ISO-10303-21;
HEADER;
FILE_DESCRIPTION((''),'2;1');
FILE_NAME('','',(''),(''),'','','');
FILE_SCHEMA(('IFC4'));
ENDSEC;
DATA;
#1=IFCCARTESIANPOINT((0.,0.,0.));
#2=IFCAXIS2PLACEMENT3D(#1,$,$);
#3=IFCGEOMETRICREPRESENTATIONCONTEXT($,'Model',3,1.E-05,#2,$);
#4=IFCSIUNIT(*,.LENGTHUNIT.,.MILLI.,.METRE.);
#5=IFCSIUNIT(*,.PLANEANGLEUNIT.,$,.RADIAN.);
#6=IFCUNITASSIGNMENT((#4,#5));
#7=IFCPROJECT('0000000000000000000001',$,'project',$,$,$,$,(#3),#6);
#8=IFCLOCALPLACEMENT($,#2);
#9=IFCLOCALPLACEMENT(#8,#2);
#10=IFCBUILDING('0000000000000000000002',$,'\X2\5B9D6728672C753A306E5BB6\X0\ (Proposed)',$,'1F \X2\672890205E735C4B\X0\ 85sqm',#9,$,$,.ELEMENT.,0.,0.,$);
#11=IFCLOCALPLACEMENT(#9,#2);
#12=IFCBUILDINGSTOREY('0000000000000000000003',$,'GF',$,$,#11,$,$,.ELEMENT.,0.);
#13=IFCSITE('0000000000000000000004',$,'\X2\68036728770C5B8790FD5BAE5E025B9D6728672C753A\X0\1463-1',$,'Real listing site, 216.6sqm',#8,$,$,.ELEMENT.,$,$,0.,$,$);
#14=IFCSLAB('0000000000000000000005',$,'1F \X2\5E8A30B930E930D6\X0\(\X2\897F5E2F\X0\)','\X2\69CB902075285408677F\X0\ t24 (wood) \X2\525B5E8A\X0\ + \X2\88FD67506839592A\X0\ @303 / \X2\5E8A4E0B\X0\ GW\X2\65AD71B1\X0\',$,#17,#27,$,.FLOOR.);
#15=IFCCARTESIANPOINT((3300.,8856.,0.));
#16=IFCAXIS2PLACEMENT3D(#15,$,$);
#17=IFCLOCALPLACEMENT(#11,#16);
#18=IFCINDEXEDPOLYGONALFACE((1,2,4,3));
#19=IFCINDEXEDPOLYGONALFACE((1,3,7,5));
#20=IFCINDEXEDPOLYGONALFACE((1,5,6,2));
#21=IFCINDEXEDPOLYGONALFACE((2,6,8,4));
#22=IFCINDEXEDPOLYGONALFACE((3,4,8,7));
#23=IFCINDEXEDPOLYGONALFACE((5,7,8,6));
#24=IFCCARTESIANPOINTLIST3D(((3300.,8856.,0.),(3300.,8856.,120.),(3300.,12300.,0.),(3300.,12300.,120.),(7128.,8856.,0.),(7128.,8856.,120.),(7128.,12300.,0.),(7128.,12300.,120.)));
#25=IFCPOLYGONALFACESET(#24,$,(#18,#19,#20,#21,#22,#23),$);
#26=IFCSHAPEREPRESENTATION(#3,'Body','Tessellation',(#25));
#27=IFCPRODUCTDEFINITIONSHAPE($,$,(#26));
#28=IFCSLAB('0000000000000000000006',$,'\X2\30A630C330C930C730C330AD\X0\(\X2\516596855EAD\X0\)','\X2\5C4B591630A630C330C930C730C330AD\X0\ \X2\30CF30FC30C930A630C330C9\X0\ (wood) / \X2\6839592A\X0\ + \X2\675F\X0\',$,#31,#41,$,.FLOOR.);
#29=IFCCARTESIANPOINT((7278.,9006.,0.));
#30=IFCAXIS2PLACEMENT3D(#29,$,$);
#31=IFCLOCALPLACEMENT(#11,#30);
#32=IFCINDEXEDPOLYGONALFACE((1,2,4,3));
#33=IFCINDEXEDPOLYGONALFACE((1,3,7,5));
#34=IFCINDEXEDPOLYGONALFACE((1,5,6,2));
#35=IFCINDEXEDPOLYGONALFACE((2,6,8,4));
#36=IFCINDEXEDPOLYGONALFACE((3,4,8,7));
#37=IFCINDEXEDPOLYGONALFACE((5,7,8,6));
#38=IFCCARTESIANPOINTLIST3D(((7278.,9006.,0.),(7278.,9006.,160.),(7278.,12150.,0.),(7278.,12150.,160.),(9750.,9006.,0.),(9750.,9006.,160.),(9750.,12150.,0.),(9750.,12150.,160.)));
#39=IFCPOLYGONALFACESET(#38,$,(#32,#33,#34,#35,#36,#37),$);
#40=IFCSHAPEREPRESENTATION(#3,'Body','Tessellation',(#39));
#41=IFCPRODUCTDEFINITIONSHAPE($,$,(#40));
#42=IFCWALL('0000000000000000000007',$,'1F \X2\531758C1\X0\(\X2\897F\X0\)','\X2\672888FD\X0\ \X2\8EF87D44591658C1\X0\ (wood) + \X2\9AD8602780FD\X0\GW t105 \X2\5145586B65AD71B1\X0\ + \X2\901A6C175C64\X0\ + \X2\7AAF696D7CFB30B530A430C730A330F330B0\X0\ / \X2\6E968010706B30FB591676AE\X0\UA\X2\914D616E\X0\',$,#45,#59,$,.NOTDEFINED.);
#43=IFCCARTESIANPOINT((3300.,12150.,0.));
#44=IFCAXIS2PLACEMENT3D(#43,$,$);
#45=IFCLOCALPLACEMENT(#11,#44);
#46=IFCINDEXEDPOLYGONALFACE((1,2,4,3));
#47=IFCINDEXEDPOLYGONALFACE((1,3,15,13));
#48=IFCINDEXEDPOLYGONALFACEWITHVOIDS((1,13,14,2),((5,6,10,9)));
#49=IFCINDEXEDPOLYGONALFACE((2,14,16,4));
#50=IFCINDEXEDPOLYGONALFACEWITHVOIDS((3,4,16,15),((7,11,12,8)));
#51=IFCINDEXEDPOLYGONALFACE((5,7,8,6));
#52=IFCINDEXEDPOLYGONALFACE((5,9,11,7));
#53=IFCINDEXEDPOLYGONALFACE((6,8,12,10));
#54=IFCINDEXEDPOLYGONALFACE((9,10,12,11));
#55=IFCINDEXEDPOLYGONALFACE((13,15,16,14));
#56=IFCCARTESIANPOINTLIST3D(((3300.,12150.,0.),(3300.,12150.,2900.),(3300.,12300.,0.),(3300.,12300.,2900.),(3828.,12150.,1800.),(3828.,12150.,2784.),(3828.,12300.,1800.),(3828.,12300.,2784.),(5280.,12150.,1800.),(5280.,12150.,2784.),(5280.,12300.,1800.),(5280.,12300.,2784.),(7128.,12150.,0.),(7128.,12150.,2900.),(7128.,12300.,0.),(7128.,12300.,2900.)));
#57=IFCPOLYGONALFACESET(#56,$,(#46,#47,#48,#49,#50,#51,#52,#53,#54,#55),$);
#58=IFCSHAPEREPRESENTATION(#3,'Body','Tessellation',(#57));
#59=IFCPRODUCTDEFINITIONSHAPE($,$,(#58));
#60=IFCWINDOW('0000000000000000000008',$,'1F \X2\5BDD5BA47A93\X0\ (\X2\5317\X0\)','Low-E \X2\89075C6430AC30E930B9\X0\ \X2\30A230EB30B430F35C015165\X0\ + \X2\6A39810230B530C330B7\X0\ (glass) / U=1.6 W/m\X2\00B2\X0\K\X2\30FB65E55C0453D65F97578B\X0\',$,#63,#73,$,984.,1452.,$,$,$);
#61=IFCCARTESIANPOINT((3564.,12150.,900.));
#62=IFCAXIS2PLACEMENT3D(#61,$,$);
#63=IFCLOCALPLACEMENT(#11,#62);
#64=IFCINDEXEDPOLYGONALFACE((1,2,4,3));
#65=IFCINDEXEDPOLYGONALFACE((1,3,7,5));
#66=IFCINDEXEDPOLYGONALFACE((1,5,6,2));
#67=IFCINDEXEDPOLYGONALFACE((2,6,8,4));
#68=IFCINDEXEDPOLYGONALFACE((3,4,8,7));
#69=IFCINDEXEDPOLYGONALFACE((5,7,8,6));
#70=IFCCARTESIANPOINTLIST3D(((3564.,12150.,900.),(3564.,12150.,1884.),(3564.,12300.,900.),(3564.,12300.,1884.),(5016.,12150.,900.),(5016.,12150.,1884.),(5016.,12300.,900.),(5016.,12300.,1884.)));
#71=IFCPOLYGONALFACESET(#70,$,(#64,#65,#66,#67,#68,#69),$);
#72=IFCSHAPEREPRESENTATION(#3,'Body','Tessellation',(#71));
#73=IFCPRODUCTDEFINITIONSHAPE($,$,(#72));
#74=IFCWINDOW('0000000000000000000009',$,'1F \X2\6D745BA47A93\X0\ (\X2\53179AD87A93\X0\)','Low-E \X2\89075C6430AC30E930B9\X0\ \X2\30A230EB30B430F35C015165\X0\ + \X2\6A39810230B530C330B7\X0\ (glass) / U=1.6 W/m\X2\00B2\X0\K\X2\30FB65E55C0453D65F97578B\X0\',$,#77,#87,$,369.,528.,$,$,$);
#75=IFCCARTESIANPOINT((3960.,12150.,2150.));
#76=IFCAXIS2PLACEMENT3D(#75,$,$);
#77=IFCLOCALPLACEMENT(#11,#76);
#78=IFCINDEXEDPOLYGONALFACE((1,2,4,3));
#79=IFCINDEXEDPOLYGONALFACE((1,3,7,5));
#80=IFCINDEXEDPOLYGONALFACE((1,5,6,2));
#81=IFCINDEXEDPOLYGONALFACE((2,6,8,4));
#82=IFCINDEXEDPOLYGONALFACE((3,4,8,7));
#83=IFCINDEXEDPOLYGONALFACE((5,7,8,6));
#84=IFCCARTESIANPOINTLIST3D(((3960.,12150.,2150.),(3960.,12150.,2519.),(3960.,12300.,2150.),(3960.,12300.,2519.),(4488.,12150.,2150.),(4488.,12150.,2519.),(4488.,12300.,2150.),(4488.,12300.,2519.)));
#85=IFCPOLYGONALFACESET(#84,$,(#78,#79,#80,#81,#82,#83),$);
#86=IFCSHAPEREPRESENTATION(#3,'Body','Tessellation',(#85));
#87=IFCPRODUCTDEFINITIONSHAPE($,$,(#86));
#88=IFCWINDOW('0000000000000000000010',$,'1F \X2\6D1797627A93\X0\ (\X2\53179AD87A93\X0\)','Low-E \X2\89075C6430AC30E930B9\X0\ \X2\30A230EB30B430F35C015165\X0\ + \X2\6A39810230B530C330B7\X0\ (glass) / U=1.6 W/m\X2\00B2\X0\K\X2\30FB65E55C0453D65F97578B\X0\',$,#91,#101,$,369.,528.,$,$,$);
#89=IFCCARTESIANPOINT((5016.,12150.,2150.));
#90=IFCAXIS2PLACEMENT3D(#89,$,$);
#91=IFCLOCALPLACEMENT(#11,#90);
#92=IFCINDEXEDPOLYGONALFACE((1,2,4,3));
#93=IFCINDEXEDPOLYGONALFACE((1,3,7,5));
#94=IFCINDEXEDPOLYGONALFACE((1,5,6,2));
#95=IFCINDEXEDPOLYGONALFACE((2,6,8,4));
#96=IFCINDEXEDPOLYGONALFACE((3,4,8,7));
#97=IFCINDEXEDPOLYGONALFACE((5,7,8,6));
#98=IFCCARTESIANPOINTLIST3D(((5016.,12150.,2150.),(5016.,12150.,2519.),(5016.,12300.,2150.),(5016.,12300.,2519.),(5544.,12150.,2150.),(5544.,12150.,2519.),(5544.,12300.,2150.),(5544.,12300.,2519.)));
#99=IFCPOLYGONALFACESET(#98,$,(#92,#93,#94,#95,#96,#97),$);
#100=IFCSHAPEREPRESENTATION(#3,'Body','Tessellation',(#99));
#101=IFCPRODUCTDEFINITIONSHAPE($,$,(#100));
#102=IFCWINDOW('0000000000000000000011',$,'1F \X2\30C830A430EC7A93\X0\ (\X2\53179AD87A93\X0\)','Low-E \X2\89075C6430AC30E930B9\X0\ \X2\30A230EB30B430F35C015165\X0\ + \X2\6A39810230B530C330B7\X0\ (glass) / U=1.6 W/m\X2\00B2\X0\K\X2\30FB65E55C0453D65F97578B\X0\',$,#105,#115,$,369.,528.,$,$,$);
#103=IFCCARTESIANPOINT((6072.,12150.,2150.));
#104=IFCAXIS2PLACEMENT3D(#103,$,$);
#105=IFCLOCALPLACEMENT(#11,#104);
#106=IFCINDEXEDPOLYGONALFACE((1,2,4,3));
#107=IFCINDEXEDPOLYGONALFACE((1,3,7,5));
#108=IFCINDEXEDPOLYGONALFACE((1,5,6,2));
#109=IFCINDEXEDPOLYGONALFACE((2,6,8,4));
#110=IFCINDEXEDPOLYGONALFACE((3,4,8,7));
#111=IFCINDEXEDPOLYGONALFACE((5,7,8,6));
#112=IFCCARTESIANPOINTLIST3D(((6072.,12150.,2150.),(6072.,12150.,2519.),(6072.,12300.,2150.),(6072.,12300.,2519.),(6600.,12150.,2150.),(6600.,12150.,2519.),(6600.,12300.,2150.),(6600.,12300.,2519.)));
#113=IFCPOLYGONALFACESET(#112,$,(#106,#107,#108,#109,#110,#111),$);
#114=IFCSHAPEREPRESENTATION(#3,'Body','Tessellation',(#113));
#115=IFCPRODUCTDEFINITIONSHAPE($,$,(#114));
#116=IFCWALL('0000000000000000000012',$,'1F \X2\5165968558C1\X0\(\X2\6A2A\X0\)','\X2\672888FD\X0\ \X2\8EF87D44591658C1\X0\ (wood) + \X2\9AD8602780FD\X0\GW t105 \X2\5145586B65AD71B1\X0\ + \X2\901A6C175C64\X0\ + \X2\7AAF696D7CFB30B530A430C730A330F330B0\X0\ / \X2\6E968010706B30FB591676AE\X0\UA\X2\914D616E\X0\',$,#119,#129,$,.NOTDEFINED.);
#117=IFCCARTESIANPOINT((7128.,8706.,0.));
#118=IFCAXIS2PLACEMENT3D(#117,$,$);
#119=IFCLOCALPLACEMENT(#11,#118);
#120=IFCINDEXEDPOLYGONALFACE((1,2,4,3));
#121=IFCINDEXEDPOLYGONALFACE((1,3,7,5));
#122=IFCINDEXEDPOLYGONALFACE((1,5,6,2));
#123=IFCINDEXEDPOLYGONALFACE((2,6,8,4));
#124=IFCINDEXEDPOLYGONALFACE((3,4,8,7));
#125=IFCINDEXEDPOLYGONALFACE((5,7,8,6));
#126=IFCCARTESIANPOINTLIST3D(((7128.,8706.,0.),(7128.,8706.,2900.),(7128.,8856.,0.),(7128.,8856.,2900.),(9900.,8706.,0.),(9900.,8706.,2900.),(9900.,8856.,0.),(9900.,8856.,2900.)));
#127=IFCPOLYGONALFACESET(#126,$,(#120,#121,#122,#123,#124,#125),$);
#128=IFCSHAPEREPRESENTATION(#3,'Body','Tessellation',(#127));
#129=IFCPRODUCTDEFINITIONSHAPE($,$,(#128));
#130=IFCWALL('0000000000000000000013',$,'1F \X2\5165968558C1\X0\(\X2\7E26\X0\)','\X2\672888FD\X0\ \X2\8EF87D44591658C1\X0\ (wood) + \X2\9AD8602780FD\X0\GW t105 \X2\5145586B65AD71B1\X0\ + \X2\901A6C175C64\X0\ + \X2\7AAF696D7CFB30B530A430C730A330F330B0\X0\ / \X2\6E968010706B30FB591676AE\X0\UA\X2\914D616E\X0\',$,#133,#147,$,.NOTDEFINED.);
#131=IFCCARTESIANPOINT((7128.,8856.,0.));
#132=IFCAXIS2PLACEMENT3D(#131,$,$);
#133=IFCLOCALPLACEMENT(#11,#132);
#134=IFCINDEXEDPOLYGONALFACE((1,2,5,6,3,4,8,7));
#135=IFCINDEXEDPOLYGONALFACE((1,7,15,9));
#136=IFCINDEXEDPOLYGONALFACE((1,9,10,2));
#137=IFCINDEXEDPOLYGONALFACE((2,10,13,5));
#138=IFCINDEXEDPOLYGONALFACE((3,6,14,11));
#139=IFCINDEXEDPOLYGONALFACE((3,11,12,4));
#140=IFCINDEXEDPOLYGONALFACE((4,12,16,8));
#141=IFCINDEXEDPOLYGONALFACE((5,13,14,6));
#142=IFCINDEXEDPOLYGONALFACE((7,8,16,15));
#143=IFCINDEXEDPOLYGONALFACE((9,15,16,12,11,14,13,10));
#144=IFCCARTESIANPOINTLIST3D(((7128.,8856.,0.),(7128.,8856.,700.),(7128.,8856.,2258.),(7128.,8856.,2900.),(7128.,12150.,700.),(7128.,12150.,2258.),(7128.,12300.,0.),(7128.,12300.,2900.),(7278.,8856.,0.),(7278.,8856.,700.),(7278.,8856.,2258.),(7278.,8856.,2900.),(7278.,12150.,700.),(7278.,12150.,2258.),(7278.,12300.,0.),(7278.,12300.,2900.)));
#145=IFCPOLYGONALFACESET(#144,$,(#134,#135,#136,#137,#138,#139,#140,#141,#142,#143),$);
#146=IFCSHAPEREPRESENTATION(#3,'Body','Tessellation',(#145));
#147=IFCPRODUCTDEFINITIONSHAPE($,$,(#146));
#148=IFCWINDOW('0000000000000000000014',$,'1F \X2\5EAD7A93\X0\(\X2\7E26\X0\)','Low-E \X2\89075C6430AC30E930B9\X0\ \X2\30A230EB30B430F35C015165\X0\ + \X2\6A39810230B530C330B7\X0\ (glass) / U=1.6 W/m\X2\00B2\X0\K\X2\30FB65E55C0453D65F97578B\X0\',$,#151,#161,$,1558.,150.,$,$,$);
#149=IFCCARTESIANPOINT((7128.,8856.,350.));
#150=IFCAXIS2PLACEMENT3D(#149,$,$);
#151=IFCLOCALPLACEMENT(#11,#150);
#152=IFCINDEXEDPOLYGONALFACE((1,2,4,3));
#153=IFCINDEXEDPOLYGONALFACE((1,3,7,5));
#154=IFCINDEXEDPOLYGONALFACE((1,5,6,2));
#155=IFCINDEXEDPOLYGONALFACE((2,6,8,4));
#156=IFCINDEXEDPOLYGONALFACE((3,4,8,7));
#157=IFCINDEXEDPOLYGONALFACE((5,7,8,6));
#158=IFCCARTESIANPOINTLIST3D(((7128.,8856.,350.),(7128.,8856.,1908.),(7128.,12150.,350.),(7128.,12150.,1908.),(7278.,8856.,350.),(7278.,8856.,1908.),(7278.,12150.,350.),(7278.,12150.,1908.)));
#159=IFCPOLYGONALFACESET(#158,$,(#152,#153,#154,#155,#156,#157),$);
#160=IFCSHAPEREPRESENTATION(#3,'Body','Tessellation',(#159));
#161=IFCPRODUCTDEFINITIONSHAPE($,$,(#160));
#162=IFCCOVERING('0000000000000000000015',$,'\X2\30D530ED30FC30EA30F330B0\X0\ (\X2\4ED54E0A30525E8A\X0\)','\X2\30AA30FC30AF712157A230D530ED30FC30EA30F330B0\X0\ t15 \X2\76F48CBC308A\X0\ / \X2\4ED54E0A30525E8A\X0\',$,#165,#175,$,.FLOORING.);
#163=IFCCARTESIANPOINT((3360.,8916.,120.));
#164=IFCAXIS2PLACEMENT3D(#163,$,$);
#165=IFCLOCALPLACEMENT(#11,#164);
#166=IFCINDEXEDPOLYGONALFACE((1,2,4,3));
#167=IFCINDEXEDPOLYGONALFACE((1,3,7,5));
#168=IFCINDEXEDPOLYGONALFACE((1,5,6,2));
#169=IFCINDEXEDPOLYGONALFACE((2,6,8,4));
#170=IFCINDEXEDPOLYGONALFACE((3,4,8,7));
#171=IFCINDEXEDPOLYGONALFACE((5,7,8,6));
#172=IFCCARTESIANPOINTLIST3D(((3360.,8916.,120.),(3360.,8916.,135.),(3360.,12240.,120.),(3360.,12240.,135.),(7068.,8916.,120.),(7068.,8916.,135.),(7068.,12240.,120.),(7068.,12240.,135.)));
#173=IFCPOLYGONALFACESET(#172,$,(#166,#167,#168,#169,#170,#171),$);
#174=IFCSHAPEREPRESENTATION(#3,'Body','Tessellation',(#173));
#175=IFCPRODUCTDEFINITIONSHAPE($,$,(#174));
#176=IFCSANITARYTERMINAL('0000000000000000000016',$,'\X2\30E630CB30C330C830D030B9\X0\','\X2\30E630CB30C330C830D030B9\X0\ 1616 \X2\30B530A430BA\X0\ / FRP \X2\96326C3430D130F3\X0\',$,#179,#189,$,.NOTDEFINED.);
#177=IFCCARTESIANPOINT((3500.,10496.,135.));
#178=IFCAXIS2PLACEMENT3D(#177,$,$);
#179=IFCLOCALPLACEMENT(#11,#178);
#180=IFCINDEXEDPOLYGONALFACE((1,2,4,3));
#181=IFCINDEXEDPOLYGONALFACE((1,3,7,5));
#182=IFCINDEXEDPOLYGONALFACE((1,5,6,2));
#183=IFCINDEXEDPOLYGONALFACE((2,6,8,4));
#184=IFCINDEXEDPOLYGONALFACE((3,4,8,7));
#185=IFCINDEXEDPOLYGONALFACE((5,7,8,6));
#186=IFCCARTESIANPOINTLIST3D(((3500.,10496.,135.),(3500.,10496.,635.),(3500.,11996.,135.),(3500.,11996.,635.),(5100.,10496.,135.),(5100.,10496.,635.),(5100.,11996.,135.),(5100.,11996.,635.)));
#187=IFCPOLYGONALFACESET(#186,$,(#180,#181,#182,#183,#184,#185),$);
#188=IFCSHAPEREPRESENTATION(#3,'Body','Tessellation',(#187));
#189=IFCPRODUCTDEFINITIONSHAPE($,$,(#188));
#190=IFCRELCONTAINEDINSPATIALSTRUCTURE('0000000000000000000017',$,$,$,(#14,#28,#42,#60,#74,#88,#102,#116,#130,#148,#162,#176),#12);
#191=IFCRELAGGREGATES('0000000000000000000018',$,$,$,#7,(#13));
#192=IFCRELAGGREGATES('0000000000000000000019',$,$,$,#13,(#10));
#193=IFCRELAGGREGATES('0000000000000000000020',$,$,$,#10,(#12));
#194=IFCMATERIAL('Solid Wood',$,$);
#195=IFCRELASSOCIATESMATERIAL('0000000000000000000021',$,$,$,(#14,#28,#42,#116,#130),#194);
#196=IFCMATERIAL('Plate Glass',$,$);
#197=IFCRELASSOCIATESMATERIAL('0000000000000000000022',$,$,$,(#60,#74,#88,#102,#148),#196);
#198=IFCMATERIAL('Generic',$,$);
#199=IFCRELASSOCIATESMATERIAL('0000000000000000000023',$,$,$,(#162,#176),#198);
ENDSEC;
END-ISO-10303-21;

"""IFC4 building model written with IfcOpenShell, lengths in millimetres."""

from ifc_helpers import new_model, si_unit, frame, frame_2d, origin, place, context, project, spatial, rectangle, extrude, material, element, fill, save


model = new_model("IFC4")

# Units and contexts
model_context = context("Model", 3, precision=1e-05, world=origin())
ifc_project = project(units=[si_unit("LENGTHUNIT", "METRE", prefix="MILLI"), si_unit("PLANEANGLEUNIT", "RADIAN")], contexts=[model_context])

# Site, building, storey
site_placement = place(None, origin())
site = spatial("IfcSite", under=ifc_project, at=site_placement, Name="栃木県宇都宮市宝木本町1463-1", ObjectType="Real listing site, 216.6sqm", CompositionType="ELEMENT", RefElevation=0.0)
building_placement = place(site_placement, origin())
building = spatial("IfcBuilding", under=site, at=building_placement, Name="宝木本町の家 (Proposed)", ObjectType="1F 木造平屋 85sqm", CompositionType="ELEMENT", ElevationOfRefHeight=0.0, ElevationOfTerrain=0.0)
storey_placement = place(building_placement, origin())
storey = spatial("IfcBuildingStorey", under=building, at=storey_placement, Name="GF", CompositionType="ELEMENT", Elevation=0.0)

# Slabs
ifc_material_1 = material(Name="Solid Wood")
slab_1_placement = place(storey_placement, frame((3300.0, 8856.0, 0.0)))
element("IfcSlab", 1, at=slab_1_placement, inside=storey, material=ifc_material_1, Name="1F 床スラブ(西帯)", Description="構造用合板 t24 (wood) 剛床 + 製材根太 @303 / 床下 GW断熱", PredefinedType="FLOOR", context=model_context, shape_type="SweptSolid", body=[
    extrude(rectangle(XDim=3828.0, YDim=3444.0, at=frame_2d((1914.0, 1722.0))), frame((3300.0, 8856.0, 0.0)), (0.0, 0.0, 1.0), 120.0),
])
slab_2_placement = place(storey_placement, frame((7278.0, 9006.0, 0.0)))
element("IfcSlab", 2, at=slab_2_placement, inside=storey, material=ifc_material_1, Name="ウッドデッキ(入隅庭)", Description="屋外ウッドデッキ ハードウッド (wood) / 根太 + 束", PredefinedType="FLOOR", context=model_context, shape_type="SweptSolid", body=[
    extrude(rectangle(XDim=2472.0, YDim=3144.0, at=frame_2d((1236.0, 1572.0))), frame((7278.0, 9006.0, 0.0)), (0.0, 0.0, 1.0), 160.0),
])

# Wall, openings, windows
wall_1_placement = place(storey_placement, frame((3300.0, 12150.0, 0.0)))
wall_1 = element("IfcWall", 3, at=wall_1_placement, inside=storey, material=ifc_material_1, Name="1F 北壁(西)", Description="木製 軸組外壁 (wood) + 高性能GW t105 充填断熱 + 通気層 + 窯業系サイディング / 準耐火・外皮UA配慮", PredefinedType="NOTDEFINED", context=model_context, shape_type="SweptSolid", body=[
    extrude(rectangle(XDim=3828.0, YDim=150.0, at=frame_2d((1914.0, 75.0))), frame((3300.0, 12150.0, 0.0)), (0.0, 0.0, 1.0), 2900.0),
])
opening_1_placement = place(storey_placement, frame((3564.0, 12150.0, 900.0)))
opening_1 = element("IfcOpeningElement", 4, at=opening_1_placement, cuts=wall_1, PredefinedType="NOTDEFINED", context=model_context, shape_type="SweptSolid", body=[
    extrude(rectangle(XDim=1452.0, YDim=150.0, at=frame_2d((726.0, 75.0))), frame((3564.0, 12150.0, 900.0)), (0.0, 0.0, 1.0), 984.0),
])
opening_2_placement = place(storey_placement, frame((3960.0, 12150.0, 2150.0)))
opening_2 = element("IfcOpeningElement", 5, at=opening_2_placement, cuts=wall_1, PredefinedType="NOTDEFINED", context=model_context, shape_type="SweptSolid", body=[
    extrude(rectangle(XDim=528.0, YDim=150.0, at=frame_2d((264.0, 75.0))), frame((3960.0, 12150.0, 2150.0)), (0.0, 0.0, 1.0), 369.0),
])
opening_3_placement = place(storey_placement, frame((5016.0, 12150.0, 2150.0)))
opening_3 = element("IfcOpeningElement", 6, at=opening_3_placement, cuts=wall_1, PredefinedType="NOTDEFINED", context=model_context, shape_type="SweptSolid", body=[
    extrude(rectangle(XDim=528.0, YDim=150.0, at=frame_2d((264.0, 75.0))), frame((5016.0, 12150.0, 2150.0)), (0.0, 0.0, 1.0), 369.0),
])
opening_4_placement = place(storey_placement, frame((6072.0, 12150.0, 2150.0)))
opening_4 = element("IfcOpeningElement", 7, at=opening_4_placement, cuts=wall_1, PredefinedType="NOTDEFINED", context=model_context, shape_type="SweptSolid", body=[
    extrude(rectangle(XDim=528.0, YDim=150.0, at=frame_2d((264.0, 75.0))), frame((6072.0, 12150.0, 2150.0)), (0.0, 0.0, 1.0), 369.0),
])
ifc_material_2 = material(Name="Plate Glass")
window_1_placement = place(storey_placement, frame((3564.0, 12150.0, 900.0)))
window_1 = element("IfcWindow", 8, at=window_1_placement, inside=storey, material=ifc_material_2, Name="1F 寝室窓 (北)", Description="Low-E 複層ガラス アルゴン封入 + 樹脂サッシ (glass) / U=1.6 W/m²K・日射取得型", OverallHeight=984.0, OverallWidth=1452.0, context=model_context, shape_type="SweptSolid", body=[
    extrude(rectangle(XDim=1452.0, YDim=150.0, at=frame_2d((726.0, 75.0))), frame((3564.0, 12150.0, 900.0)), (0.0, 0.0, 1.0), 984.0),
])
fill(opening_1, window_1)
window_2_placement = place(storey_placement, frame((3960.0, 12150.0, 2150.0)))
window_2 = element("IfcWindow", 9, at=window_2_placement, inside=storey, material=ifc_material_2, Name="1F 浴室窓 (北高窓)", Description="Low-E 複層ガラス アルゴン封入 + 樹脂サッシ (glass) / U=1.6 W/m²K・日射取得型", OverallHeight=369.0, OverallWidth=528.0, context=model_context, shape_type="SweptSolid", body=[
    extrude(rectangle(XDim=528.0, YDim=150.0, at=frame_2d((264.0, 75.0))), frame((3960.0, 12150.0, 2150.0)), (0.0, 0.0, 1.0), 369.0),
])
fill(opening_2, window_2)
window_3_placement = place(storey_placement, frame((5016.0, 12150.0, 2150.0)))
window_3 = element("IfcWindow", 10, at=window_3_placement, inside=storey, material=ifc_material_2, Name="1F 洗面窓 (北高窓)", Description="Low-E 複層ガラス アルゴン封入 + 樹脂サッシ (glass) / U=1.6 W/m²K・日射取得型", OverallHeight=369.0, OverallWidth=528.0, context=model_context, shape_type="SweptSolid", body=[
    extrude(rectangle(XDim=528.0, YDim=150.0, at=frame_2d((264.0, 75.0))), frame((5016.0, 12150.0, 2150.0)), (0.0, 0.0, 1.0), 369.0),
])
fill(opening_3, window_3)
window_4_placement = place(storey_placement, frame((6072.0, 12150.0, 2150.0)))
window_4 = element("IfcWindow", 11, at=window_4_placement, inside=storey, material=ifc_material_2, Name="1F トイレ窓 (北高窓)", Description="Low-E 複層ガラス アルゴン封入 + 樹脂サッシ (glass) / U=1.6 W/m²K・日射取得型", OverallHeight=369.0, OverallWidth=528.0, context=model_context, shape_type="SweptSolid", body=[
    extrude(rectangle(XDim=528.0, YDim=150.0, at=frame_2d((264.0, 75.0))), frame((6072.0, 12150.0, 2150.0)), (0.0, 0.0, 1.0), 369.0),
])
fill(opening_4, window_4)

# Wall
wall_2_placement = place(storey_placement, frame((7128.0, 8706.0, 0.0)))
element("IfcWall", 12, at=wall_2_placement, inside=storey, material=ifc_material_1, Name="1F 入隅壁(横)", Description="木製 軸組外壁 (wood) + 高性能GW t105 充填断熱 + 通気層 + 窯業系サイディング / 準耐火・外皮UA配慮", PredefinedType="NOTDEFINED", context=model_context, shape_type="SweptSolid", body=[
    extrude(rectangle(XDim=2772.0, YDim=150.0, at=frame_2d((1386.0, 75.0))), frame((7128.0, 8706.0, 0.0)), (0.0, 0.0, 1.0), 2900.0),
])

# Wall, opening, window
wall_3_placement = place(storey_placement, frame((7128.0, 8856.0, 0.0)))
wall_3 = element("IfcWall", 13, at=wall_3_placement, inside=storey, material=ifc_material_1, Name="1F 入隅壁(縦)", Description="木製 軸組外壁 (wood) + 高性能GW t105 充填断熱 + 通気層 + 窯業系サイディング / 準耐火・外皮UA配慮", PredefinedType="NOTDEFINED", context=model_context, shape_type="SweptSolid", body=[
    extrude(rectangle(XDim=150.0, YDim=3444.0, at=frame_2d((75.0, 1722.0))), frame((7128.0, 8856.0, 0.0)), (0.0, 0.0, 1.0), 2900.0),
])
opening_5_placement = place(storey_placement, frame((7128.0, 8856.0, 350.0)))
opening_5 = element("IfcOpeningElement", 14, at=opening_5_placement, cuts=wall_3, PredefinedType="NOTDEFINED", context=model_context, shape_type="SweptSolid", body=[
    extrude(rectangle(XDim=150.0, YDim=3294.0, at=frame_2d((75.0, 1647.0))), frame((7128.0, 8856.0, 350.0)), (0.0, 0.0, 1.0), 1558.0),
])
window_5_placement = place(storey_placement, frame((7128.0, 8856.0, 350.0)))
window_5 = element("IfcWindow", 15, at=window_5_placement, inside=storey, material=ifc_material_2, Name="1F 庭窓(縦)", Description="Low-E 複層ガラス アルゴン封入 + 樹脂サッシ (glass) / U=1.6 W/m²K・日射取得型", OverallHeight=1558.0, OverallWidth=150.0, context=model_context, shape_type="SweptSolid", body=[
    extrude(rectangle(XDim=150.0, YDim=3294.0, at=frame_2d((75.0, 1647.0))), frame((7128.0, 8856.0, 350.0)), (0.0, 0.0, 1.0), 1558.0),
])
fill(opening_5, window_5)

# Covering
ifc_material_3 = material(Name="Generic")
covering_placement = place(storey_placement, frame((3360.0, 8916.0, 120.0)))
element("IfcCovering", 16, at=covering_placement, inside=storey, material=ifc_material_3, Name="フローリング (仕上げ床)", Description="オーク無垢フローリング t15 直貼り / 仕上げ床", PredefinedType="FLOORING", context=model_context, shape_type="SweptSolid", body=[
    extrude(rectangle(XDim=3708.0, YDim=3324.0, at=frame_2d((1854.0, 1662.0))), frame((3360.0, 8916.0, 120.0)), (0.0, 0.0, 1.0), 15.0),
])

# Sanitary terminal
sanitary_terminal_1_placement = place(storey_placement, frame((3500.0, 10496.0, 135.0)))
element("IfcSanitaryTerminal", 17, at=sanitary_terminal_1_placement, inside=storey, material=ifc_material_3, Name="ユニットバス", Description="ユニットバス 1616 サイズ / FRP 防水パン", PredefinedType="NOTDEFINED", context=model_context, shape_type="SweptSolid", body=[
    extrude(rectangle(XDim=1600.0, YDim=1500.0, at=frame_2d((800.0, 750.0))), frame((3500.0, 10496.0, 135.0)), (0.0, 0.0, 1.0), 500.0),
])

save(model, "model.ifc")
